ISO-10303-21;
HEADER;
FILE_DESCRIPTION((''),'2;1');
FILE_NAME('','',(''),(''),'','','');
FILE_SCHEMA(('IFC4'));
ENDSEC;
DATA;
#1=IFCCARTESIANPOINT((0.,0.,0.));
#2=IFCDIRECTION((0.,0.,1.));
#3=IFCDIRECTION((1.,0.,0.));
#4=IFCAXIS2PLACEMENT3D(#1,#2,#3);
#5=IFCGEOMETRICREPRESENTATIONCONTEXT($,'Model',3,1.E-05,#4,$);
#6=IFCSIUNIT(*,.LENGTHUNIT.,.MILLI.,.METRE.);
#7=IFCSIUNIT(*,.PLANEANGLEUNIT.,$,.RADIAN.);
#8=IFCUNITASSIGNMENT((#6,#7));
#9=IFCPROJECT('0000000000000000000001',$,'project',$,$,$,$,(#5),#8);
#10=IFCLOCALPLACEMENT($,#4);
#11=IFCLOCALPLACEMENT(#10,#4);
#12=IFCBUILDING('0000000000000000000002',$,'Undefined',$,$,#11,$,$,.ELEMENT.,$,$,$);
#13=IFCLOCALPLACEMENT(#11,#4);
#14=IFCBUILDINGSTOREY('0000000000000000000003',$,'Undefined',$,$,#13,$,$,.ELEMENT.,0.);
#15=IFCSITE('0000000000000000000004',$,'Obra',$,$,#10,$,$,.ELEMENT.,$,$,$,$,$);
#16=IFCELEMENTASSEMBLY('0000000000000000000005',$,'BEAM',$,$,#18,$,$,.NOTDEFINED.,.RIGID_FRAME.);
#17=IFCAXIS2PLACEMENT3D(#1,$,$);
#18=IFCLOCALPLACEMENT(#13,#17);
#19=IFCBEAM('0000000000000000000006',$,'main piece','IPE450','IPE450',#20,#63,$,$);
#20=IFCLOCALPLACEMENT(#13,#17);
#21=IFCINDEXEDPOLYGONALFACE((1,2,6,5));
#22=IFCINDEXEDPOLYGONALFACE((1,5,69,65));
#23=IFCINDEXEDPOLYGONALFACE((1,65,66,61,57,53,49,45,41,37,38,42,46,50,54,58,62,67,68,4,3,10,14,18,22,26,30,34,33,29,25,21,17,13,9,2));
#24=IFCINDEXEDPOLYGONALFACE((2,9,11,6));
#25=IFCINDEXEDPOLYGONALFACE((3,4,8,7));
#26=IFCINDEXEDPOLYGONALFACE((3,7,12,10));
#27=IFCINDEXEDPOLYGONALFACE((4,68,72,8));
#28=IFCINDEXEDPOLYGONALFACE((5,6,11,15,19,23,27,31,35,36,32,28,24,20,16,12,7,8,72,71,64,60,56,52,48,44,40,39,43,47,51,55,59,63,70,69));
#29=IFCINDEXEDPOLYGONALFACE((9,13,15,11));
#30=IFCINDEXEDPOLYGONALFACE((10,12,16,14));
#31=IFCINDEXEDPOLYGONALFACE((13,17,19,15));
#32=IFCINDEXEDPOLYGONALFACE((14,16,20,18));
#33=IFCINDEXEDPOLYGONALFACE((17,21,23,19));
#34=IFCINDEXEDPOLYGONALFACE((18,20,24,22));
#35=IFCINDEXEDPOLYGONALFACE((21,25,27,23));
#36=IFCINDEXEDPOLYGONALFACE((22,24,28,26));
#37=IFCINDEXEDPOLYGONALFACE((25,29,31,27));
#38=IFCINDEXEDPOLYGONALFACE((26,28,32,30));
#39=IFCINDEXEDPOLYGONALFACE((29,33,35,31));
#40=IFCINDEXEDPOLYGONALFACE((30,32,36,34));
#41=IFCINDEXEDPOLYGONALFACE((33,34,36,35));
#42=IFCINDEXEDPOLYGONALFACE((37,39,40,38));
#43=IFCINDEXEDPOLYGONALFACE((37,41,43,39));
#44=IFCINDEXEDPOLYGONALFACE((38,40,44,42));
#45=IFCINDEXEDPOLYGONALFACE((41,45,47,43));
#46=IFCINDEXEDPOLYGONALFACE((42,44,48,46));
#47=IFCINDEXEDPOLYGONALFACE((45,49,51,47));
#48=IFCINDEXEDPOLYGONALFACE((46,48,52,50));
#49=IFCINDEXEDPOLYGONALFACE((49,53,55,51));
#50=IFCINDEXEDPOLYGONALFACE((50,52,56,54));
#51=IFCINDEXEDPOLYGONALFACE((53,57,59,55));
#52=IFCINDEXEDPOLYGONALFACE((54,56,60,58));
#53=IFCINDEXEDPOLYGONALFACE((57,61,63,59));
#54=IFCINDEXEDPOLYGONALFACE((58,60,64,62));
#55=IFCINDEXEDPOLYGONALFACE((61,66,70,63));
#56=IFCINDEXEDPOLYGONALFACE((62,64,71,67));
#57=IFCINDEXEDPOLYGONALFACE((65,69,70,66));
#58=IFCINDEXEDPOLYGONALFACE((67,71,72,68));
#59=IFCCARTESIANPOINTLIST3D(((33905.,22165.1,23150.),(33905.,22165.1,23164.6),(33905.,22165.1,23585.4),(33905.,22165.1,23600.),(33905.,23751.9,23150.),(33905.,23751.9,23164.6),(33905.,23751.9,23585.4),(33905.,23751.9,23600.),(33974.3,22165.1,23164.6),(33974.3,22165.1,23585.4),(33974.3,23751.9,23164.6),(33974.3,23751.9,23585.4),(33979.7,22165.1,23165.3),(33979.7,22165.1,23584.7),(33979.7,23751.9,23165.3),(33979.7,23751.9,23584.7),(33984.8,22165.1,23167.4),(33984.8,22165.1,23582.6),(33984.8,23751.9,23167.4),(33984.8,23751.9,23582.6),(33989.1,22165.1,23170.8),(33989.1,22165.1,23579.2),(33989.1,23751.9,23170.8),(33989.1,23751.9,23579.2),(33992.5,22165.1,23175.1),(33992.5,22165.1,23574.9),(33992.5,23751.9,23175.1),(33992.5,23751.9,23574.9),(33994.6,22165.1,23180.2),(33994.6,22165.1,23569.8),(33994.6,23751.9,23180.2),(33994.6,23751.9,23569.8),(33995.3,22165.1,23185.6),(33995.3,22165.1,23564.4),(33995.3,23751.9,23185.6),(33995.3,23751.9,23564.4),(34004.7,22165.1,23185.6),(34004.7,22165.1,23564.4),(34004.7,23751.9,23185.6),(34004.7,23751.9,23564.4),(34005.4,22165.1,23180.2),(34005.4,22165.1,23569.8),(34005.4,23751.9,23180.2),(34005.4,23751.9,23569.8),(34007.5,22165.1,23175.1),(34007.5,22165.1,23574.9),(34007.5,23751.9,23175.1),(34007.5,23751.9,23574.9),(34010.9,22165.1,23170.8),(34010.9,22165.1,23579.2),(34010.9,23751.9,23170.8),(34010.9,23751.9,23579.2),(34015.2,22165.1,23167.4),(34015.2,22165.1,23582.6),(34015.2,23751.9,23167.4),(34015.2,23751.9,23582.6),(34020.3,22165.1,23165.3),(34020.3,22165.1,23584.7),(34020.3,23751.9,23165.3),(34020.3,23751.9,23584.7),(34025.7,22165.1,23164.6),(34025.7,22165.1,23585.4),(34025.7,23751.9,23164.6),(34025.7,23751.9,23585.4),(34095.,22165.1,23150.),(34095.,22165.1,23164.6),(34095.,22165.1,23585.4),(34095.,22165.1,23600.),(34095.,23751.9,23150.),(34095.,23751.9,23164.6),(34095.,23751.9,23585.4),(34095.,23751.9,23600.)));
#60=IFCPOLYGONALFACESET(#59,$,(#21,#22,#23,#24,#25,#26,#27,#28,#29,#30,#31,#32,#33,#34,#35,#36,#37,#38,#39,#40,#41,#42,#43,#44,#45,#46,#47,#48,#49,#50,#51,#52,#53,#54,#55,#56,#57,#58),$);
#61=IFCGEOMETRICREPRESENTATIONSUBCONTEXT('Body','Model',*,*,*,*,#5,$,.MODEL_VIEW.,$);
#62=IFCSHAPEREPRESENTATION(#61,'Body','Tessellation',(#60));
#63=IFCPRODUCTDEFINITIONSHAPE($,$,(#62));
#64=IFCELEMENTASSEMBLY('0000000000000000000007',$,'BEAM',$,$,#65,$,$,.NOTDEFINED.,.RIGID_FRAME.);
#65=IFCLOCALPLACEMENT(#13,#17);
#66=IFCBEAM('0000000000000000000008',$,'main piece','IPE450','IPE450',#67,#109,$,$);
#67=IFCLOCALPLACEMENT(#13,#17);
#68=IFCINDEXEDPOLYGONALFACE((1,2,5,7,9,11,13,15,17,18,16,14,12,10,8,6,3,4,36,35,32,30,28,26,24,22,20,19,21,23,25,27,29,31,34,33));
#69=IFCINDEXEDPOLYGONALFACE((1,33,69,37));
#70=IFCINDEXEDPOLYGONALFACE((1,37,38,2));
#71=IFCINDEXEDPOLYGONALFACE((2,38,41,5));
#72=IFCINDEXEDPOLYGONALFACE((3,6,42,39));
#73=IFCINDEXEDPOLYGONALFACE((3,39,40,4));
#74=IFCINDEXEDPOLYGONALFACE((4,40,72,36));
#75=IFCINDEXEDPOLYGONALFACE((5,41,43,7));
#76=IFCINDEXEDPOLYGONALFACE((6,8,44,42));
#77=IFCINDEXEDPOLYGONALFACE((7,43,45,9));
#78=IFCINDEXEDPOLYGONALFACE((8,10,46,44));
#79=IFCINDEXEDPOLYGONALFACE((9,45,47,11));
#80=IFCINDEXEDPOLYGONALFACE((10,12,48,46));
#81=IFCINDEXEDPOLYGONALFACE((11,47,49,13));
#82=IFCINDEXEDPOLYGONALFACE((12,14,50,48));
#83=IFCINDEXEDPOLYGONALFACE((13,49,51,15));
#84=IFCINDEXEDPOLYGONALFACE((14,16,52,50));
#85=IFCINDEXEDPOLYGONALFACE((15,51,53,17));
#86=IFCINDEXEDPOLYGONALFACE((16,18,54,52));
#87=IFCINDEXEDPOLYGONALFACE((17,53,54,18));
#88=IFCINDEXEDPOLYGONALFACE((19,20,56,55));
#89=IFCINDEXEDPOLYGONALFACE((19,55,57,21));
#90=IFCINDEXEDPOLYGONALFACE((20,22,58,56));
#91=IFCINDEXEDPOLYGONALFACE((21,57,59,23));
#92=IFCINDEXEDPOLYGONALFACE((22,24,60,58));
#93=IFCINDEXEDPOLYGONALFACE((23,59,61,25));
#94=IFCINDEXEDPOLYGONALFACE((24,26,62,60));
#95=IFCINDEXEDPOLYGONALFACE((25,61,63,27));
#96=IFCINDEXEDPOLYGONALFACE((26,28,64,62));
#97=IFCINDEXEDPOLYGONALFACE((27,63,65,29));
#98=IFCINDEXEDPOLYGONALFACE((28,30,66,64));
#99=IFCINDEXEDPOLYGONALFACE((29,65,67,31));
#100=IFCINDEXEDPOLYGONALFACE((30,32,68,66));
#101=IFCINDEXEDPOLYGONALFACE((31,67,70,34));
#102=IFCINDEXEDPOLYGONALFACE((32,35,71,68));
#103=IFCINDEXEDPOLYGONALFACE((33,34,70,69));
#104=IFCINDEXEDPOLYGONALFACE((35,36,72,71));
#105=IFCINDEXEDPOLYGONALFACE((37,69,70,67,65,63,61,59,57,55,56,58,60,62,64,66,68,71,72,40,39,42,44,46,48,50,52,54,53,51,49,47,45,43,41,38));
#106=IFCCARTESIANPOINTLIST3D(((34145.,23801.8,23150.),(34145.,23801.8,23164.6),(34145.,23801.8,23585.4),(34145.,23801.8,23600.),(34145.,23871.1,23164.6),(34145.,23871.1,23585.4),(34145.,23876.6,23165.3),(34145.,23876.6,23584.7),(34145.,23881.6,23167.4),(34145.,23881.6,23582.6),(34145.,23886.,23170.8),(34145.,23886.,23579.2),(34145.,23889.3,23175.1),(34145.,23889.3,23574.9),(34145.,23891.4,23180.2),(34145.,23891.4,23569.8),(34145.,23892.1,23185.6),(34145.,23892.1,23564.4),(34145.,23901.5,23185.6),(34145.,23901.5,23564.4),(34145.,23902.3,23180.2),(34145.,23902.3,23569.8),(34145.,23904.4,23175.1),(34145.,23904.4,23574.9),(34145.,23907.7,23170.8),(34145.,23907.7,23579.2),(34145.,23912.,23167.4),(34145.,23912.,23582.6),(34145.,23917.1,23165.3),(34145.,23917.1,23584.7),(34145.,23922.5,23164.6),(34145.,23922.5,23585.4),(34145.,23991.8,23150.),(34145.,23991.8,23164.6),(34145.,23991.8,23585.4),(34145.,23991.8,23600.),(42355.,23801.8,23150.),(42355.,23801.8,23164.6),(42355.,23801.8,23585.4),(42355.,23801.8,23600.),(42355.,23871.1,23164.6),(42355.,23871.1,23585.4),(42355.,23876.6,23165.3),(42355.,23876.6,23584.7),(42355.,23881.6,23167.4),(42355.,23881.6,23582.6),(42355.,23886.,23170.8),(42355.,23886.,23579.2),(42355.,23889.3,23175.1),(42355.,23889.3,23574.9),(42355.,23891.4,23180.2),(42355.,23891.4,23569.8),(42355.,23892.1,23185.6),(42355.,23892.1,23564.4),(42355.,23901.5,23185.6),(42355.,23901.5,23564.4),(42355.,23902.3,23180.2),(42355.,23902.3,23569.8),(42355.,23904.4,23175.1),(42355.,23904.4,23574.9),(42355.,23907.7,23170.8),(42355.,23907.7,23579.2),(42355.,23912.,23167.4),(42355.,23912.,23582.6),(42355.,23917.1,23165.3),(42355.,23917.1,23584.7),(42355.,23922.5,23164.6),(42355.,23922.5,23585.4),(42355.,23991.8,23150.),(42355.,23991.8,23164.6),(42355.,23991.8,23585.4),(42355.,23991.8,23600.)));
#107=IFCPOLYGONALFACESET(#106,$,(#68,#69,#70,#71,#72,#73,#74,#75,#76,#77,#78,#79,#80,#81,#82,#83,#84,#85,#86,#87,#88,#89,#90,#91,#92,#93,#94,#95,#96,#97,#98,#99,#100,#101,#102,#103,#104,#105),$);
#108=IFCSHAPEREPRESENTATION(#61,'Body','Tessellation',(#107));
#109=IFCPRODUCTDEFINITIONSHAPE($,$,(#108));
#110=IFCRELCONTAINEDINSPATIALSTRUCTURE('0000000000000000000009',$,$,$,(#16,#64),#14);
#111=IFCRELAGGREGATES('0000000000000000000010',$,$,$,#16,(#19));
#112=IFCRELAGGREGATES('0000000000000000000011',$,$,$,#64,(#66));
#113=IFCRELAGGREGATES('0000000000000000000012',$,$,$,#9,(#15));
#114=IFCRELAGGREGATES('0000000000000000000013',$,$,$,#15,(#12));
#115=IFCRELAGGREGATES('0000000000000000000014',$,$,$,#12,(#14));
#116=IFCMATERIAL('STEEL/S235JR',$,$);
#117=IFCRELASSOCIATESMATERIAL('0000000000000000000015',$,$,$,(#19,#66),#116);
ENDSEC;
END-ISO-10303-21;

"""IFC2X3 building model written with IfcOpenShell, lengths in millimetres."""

from ifc_helpers import new_model, si_unit, frame, origin_with_axes, origin_2d_with_axis, place, context, subcontext, project, spatial, i_section, extrude, material, element, aggregate, save


model = new_model("IFC2X3")

# Units and contexts
model_context = context("Model", 3, precision=1e-05, world=origin_with_axes())
body_context = subcontext(model_context, "Body", "Model", "MODEL_VIEW")
ifc_project = project(units=[si_unit("LENGTHUNIT", "METRE", prefix="MILLI"), si_unit("PLANEANGLEUNIT", "RADIAN")], contexts=[model_context])

# Site, building, storey
site_placement = place(None, origin_with_axes())
site = spatial("IfcSite", under=ifc_project, at=site_placement, Name="Obra", CompositionType="ELEMENT")
building_placement = place(site_placement, origin_with_axes())
building = spatial("IfcBuilding", under=site, at=building_placement, Name="Undefined", CompositionType="ELEMENT")
storey_placement = place(building_placement, origin_with_axes())
storey = spatial("IfcBuildingStorey", under=building, at=storey_placement, Name="Undefined", CompositionType="ELEMENT", Elevation=0.0)

# Element assemblies, beams
assembly_1_placement = place(storey_placement, origin_with_axes())
assembly_1 = element("IfcElementAssembly", 1, at=assembly_1_placement, inside=storey, Name="BEAM", AssemblyPlace="NOTDEFINED", PredefinedType="RIGID_FRAME")
ifc_material_1 = material(Name="STEEL/S235JR")
beam_1_placement = place(assembly_1_placement, frame((34000.0, 22165.1, 23375.0), z_axis=(0.0, 0.0, 1.0), x_axis=(0.0, 1.0, 0.0)))
beam_1 = element("IfcBeam", 2, at=beam_1_placement, material=ifc_material_1, Name="main piece", Description="IPE450", ObjectType="IPE450", context=body_context, shape_type="SweptSolid", body=[
    extrude(i_section(OverallWidth=190.0, OverallDepth=450.0, WebThickness=9.4, FlangeThickness=14.6, FilletRadius=21.0, at=origin_2d_with_axis()), frame((1586.8, 0.0, 0.0), z_axis=(-1.0, 0.0, 0.0), x_axis=(0.0, -1.0, 0.0)), (0.0, 0.0, 1.0), 1586.8),
])
aggregate(assembly_1, [beam_1])
assembly_2_placement = place(storey_placement, origin_with_axes())
assembly_2 = element("IfcElementAssembly", 3, at=assembly_2_placement, inside=storey, Name="BEAM", AssemblyPlace="NOTDEFINED", PredefinedType="RIGID_FRAME")
beam_2_placement = place(assembly_2_placement, frame((34145.0, 23896.8, 23375.0), z_axis=(0.0, 0.0, 1.0), x_axis=(1.0, 0.0, 0.0)))
beam_2 = element("IfcBeam", 4, at=beam_2_placement, material=ifc_material_1, Name="main piece", Description="IPE450", ObjectType="IPE450", context=body_context, shape_type="SweptSolid", body=[
    extrude(i_section(OverallWidth=190.0, OverallDepth=450.0, WebThickness=9.4, FlangeThickness=14.6, FilletRadius=21.0, at=origin_2d_with_axis()), frame((8210.0, 0.0, 0.0), z_axis=(-1.0, 0.0, 0.0), x_axis=(0.0, -1.0, 0.0)), (0.0, 0.0, 1.0), 8210.0),
])
aggregate(assembly_2, [beam_2])

save(model, "model.ifc")
